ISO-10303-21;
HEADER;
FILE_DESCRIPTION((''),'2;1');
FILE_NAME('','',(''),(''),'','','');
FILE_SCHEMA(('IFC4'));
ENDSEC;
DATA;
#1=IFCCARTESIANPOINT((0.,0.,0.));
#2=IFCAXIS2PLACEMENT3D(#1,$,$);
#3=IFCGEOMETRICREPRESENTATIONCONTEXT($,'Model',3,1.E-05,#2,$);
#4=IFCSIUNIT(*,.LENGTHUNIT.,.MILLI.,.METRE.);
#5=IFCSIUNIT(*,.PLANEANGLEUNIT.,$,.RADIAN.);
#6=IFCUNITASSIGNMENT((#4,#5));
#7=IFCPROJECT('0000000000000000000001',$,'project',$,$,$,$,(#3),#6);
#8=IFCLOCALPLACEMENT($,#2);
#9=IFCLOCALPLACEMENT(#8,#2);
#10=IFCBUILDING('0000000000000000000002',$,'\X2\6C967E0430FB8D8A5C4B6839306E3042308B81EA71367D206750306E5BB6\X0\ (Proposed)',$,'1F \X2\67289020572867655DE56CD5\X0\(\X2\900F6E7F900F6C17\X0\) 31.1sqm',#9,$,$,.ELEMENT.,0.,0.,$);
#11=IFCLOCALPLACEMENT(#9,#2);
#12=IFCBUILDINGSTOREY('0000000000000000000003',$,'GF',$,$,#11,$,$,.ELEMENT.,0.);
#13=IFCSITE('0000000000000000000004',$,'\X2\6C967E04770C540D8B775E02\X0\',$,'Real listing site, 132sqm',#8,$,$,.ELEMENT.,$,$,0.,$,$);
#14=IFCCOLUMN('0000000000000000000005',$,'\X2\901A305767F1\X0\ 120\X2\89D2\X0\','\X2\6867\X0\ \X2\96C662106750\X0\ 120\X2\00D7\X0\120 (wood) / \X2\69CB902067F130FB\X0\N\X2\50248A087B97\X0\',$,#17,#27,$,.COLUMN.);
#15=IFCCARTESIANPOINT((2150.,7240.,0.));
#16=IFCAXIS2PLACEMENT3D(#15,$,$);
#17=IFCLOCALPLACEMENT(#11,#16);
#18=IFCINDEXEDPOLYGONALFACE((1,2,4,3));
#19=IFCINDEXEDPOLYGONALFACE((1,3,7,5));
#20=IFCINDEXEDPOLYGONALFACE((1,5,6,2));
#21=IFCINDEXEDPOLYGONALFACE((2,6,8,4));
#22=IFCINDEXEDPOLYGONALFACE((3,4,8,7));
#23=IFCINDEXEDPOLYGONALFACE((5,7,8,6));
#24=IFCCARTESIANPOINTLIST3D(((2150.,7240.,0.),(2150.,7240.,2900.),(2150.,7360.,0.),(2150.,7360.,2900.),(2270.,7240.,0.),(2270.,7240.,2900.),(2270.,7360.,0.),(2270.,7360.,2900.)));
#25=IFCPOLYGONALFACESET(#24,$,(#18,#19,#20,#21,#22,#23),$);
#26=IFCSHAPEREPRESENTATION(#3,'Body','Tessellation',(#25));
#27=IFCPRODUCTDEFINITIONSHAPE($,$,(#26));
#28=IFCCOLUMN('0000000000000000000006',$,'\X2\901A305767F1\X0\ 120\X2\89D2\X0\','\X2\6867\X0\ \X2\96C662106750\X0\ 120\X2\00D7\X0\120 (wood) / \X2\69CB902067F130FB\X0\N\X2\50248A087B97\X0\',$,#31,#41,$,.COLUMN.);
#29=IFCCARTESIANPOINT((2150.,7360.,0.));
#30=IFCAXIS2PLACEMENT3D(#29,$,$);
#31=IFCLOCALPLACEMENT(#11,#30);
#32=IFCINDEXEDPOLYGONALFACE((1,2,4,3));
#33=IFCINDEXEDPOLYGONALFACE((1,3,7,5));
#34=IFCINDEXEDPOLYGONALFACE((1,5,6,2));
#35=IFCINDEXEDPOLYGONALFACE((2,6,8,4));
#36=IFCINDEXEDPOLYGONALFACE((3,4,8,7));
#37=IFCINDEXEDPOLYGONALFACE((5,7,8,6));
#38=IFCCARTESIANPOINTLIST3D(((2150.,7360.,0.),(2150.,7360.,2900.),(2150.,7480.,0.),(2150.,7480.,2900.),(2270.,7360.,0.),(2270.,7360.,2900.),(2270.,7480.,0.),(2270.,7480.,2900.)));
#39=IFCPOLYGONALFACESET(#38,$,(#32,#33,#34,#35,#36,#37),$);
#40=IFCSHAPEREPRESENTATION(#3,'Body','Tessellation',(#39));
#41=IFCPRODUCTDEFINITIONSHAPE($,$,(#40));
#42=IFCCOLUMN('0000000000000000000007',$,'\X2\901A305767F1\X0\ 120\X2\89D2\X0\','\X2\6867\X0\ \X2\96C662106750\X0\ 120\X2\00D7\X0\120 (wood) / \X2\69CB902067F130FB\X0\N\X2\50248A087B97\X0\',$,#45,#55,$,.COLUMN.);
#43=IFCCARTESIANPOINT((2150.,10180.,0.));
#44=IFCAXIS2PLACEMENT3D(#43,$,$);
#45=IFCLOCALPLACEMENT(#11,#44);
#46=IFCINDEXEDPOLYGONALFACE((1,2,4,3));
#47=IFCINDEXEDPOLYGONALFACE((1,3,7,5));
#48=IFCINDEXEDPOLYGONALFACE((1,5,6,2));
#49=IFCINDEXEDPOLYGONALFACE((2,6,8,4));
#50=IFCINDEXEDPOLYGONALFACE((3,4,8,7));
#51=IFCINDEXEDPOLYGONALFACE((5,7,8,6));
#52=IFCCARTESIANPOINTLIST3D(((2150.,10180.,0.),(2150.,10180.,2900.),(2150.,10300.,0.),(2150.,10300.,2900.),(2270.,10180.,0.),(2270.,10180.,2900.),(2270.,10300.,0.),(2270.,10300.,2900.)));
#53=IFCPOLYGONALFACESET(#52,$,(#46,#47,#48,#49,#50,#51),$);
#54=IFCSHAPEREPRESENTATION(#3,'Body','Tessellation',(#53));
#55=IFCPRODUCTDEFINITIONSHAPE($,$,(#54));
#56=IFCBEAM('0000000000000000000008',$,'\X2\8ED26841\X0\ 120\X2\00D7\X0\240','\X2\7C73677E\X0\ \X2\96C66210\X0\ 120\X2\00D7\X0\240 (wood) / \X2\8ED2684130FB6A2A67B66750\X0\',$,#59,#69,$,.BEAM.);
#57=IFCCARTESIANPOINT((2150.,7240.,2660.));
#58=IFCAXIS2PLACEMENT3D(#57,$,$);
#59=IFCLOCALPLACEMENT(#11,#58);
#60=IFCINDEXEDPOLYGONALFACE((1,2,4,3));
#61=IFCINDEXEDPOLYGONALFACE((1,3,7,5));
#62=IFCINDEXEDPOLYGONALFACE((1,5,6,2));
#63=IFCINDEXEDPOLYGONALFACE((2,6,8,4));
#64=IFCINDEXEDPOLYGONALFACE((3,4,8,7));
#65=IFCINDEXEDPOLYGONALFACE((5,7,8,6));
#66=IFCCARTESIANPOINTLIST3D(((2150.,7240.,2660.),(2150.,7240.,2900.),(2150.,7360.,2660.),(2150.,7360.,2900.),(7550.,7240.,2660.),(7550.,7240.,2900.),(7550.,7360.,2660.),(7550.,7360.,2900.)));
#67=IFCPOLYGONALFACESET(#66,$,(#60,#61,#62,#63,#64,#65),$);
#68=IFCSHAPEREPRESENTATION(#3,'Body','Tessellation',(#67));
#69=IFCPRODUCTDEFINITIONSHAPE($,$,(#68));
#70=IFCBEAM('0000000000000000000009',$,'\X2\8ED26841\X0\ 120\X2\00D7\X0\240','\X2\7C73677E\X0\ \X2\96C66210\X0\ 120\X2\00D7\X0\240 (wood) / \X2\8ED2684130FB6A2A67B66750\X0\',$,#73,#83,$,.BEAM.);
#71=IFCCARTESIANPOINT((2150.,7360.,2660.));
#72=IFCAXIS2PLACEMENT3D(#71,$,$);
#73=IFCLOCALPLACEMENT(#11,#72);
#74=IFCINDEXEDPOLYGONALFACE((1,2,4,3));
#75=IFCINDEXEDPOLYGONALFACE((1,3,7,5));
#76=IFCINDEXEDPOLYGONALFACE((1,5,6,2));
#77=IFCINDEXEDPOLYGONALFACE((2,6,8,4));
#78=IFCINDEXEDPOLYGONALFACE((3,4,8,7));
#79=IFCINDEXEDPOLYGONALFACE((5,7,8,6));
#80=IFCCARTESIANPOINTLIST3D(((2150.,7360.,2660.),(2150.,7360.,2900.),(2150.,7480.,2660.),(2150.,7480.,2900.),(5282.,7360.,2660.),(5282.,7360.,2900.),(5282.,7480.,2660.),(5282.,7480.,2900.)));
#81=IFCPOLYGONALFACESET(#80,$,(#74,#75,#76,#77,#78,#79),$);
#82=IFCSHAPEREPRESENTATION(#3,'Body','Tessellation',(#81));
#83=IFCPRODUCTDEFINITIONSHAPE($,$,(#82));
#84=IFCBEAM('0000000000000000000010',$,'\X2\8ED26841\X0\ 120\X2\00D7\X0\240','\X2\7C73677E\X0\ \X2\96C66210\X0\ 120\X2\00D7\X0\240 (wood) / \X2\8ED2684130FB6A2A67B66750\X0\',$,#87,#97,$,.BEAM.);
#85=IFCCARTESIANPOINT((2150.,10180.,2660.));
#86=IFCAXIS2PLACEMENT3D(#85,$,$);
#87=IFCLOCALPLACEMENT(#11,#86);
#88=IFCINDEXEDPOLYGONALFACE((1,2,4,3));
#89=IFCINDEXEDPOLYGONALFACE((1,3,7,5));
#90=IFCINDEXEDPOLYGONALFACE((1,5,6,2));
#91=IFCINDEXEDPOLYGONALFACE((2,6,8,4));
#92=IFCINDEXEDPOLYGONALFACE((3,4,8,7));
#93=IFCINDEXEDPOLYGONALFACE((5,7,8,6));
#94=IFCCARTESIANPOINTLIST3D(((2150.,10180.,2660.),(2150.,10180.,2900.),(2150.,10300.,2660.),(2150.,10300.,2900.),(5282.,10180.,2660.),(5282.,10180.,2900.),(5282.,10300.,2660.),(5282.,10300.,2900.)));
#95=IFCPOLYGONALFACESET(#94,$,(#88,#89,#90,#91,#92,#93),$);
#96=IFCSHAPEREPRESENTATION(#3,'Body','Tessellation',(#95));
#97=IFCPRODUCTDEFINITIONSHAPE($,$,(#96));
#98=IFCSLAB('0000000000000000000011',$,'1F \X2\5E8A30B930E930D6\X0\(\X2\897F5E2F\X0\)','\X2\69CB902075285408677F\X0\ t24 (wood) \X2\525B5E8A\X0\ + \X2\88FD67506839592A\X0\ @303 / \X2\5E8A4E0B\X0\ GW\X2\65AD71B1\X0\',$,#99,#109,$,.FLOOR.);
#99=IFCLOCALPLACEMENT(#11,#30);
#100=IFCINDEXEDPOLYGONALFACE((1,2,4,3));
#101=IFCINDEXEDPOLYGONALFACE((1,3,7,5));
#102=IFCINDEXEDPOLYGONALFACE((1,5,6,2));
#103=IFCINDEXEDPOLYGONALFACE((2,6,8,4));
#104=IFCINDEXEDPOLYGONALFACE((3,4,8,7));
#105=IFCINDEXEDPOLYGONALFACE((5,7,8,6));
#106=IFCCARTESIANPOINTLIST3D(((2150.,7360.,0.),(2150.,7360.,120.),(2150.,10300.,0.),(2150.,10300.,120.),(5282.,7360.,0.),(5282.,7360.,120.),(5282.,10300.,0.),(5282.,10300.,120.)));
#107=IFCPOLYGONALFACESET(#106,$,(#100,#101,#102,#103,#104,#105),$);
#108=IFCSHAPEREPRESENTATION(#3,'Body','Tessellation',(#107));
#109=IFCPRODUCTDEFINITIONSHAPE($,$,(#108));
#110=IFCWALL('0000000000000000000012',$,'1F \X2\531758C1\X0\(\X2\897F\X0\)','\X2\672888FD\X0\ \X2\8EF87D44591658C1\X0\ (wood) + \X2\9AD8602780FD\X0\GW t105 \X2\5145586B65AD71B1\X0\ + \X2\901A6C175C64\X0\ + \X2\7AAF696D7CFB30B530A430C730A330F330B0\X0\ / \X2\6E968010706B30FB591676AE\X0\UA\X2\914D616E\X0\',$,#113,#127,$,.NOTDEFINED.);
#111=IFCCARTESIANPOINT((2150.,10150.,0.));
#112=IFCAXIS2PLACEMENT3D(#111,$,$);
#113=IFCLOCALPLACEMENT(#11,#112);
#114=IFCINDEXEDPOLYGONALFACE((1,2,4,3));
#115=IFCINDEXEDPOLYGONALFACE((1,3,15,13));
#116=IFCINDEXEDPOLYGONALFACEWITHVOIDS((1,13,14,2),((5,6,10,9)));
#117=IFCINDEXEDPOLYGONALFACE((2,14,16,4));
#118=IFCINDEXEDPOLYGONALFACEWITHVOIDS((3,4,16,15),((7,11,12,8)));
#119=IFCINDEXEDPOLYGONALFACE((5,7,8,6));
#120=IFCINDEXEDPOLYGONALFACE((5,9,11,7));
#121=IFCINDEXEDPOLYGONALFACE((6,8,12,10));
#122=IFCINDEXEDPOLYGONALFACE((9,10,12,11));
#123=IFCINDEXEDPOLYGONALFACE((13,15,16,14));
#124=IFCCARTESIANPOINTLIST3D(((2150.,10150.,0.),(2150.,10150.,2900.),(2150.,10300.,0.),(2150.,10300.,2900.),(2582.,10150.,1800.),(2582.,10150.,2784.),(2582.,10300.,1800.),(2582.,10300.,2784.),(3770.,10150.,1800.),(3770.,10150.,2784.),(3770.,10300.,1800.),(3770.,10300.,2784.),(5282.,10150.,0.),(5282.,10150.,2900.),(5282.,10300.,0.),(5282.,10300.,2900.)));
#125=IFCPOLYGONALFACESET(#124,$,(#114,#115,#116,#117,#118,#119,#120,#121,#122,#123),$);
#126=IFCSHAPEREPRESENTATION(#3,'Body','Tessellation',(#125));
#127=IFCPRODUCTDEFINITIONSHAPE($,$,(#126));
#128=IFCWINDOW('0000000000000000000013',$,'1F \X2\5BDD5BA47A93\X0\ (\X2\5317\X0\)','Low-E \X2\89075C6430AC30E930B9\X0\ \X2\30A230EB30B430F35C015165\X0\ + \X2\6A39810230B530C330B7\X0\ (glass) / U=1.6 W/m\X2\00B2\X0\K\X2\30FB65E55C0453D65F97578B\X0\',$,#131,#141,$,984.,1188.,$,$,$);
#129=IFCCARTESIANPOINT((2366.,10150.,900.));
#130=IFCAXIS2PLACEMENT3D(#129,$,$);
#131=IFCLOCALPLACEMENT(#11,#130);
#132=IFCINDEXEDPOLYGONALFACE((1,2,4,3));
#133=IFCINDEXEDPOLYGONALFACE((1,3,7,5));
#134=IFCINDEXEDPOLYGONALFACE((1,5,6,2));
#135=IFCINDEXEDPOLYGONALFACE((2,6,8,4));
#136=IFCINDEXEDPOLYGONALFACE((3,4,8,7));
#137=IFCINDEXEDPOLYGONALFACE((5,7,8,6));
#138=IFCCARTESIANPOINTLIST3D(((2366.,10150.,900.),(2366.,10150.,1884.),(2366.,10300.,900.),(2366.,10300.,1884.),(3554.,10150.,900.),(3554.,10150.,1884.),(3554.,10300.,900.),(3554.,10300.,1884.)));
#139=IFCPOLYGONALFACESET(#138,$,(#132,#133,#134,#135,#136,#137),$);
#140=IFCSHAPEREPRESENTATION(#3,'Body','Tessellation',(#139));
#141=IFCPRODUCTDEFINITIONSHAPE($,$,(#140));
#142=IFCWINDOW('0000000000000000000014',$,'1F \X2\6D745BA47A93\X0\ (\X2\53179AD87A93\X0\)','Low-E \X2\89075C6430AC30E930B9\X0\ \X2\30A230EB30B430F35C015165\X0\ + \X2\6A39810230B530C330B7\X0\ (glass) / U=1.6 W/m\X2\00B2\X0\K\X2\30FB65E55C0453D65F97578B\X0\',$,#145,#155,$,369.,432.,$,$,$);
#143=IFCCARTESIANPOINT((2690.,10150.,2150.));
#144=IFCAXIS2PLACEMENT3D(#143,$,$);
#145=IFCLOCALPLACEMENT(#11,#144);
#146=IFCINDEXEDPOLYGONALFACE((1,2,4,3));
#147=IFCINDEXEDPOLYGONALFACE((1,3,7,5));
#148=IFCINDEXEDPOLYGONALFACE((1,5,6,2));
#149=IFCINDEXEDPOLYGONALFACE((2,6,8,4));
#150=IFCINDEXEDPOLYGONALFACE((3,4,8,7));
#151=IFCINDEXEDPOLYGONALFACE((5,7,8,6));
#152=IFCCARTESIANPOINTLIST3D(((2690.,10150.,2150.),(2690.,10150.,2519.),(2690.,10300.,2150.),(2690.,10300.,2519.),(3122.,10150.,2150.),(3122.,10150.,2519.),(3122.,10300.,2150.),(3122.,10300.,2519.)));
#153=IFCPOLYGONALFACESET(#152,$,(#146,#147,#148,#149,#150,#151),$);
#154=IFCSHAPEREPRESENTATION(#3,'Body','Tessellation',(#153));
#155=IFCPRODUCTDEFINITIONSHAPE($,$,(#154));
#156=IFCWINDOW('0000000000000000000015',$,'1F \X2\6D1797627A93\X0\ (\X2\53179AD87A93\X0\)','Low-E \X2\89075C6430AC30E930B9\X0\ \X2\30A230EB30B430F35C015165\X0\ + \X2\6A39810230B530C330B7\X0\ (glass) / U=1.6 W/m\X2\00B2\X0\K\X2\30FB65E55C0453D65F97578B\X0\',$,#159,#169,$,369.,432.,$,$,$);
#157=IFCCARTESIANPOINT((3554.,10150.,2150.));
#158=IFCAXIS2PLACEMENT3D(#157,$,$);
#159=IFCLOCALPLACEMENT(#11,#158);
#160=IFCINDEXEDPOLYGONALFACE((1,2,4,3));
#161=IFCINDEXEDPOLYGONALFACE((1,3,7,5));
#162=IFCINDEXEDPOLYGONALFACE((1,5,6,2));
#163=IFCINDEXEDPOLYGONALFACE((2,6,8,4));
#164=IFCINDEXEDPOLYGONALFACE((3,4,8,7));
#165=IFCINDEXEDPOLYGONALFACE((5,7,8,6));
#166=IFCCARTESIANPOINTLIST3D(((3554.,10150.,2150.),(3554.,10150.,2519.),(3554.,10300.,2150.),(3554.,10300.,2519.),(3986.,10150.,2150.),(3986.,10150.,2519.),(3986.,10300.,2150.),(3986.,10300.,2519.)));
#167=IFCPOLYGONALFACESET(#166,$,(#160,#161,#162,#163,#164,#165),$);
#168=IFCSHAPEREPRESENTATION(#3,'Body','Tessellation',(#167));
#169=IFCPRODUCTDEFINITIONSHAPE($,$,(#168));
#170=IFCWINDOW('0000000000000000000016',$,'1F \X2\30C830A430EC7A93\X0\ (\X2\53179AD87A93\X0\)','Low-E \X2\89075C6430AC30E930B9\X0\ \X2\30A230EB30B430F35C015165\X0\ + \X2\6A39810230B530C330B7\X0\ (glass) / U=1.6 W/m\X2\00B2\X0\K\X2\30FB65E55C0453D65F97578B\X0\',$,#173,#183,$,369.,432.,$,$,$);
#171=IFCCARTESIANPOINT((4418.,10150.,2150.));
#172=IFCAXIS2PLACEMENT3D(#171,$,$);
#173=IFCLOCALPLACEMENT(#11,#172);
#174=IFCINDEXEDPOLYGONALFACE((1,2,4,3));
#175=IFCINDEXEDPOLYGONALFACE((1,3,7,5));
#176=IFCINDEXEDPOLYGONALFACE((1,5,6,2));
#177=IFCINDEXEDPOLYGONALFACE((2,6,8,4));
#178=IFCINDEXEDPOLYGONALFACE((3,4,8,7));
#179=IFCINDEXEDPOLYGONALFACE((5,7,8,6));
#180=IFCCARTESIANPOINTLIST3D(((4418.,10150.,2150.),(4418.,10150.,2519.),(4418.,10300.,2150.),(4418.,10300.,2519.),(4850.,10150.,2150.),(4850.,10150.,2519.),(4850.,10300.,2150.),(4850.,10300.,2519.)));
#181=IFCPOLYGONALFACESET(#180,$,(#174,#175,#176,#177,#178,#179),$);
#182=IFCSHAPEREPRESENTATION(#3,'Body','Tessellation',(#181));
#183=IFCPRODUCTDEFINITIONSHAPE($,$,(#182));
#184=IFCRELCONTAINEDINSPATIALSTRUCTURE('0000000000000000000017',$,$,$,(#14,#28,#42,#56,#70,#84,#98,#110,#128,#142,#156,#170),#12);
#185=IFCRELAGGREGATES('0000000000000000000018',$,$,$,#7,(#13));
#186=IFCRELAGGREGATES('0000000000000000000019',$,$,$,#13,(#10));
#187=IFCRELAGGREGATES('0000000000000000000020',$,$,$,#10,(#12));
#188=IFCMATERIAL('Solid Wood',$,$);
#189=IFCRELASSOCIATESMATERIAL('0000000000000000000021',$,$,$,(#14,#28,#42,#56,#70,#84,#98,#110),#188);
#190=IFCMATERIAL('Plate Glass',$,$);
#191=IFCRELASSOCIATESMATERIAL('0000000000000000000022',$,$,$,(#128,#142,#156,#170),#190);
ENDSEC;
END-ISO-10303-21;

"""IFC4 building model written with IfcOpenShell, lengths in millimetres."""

from ifc_helpers import new_model, si_unit, frame, frame_2d, origin, place, context, project, spatial, rectangle, extrude, material, element, fill, save


model = new_model("IFC4")

# Units and contexts
model_context = context("Model", 3, precision=1e-05, world=origin())
ifc_project = project(units=[si_unit("LENGTHUNIT", "METRE", prefix="MILLI"), si_unit("PLANEANGLEUNIT", "RADIAN")], contexts=[model_context])

# Site, building, storey
site_placement = place(None, origin())
site = spatial("IfcSite", under=ifc_project, at=site_placement, Name="沖縄県名護市", ObjectType="Real listing site, 132sqm", CompositionType="ELEMENT", RefElevation=0.0)
building_placement = place(site_placement, origin())
building = spatial("IfcBuilding", under=site, at=building_placement, Name="沖縄・越屋根のある自然素材の家 (Proposed)", ObjectType="1F 木造在来工法(透湿透気) 31.1sqm", CompositionType="ELEMENT", ElevationOfRefHeight=0.0, ElevationOfTerrain=0.0)
storey_placement = place(building_placement, origin())
storey = spatial("IfcBuildingStorey", under=building, at=storey_placement, Name="GF", CompositionType="ELEMENT", Elevation=0.0)

# Columns
ifc_material_1 = material(Name="Solid Wood")
column_1_placement = place(storey_placement, frame((2150.0, 7240.0, 0.0)))
element("IfcColumn", 1, at=column_1_placement, inside=storey, material=ifc_material_1, Name="通し柱 120角", Description="桧 集成材 120×120 (wood) / 構造柱・N値計算", PredefinedType="COLUMN", context=model_context, shape_type="SweptSolid", body=[
    extrude(rectangle(XDim=120.0, YDim=120.0, at=frame_2d((60.0, 60.0))), frame((2150.0, 7240.0, 0.0)), (0.0, 0.0, 1.0), 2900.0),
])
column_2_placement = place(storey_placement, frame((2150.0, 7360.0, 0.0)))
element("IfcColumn", 2, at=column_2_placement, inside=storey, material=ifc_material_1, Name="通し柱 120角", Description="桧 集成材 120×120 (wood) / 構造柱・N値計算", PredefinedType="COLUMN", context=model_context, shape_type="SweptSolid", body=[
    extrude(rectangle(XDim=120.0, YDim=120.0, at=frame_2d((60.0, 60.0))), frame((2150.0, 7360.0, 0.0)), (0.0, 0.0, 1.0), 2900.0),
])
column_3_placement = place(storey_placement, frame((2150.0, 10180.0, 0.0)))
element("IfcColumn", 3, at=column_3_placement, inside=storey, material=ifc_material_1, Name="通し柱 120角", Description="桧 集成材 120×120 (wood) / 構造柱・N値計算", PredefinedType="COLUMN", context=model_context, shape_type="SweptSolid", body=[
    extrude(rectangle(XDim=120.0, YDim=120.0, at=frame_2d((60.0, 60.0))), frame((2150.0, 10180.0, 0.0)), (0.0, 0.0, 1.0), 2900.0),
])

# Beams
beam_1_placement = place(storey_placement, frame((2150.0, 7240.0, 2660.0)))
element("IfcBeam", 4, at=beam_1_placement, inside=storey, material=ifc_material_1, Name="軒桁 120×240", Description="米松 集成 120×240 (wood) / 軒桁・横架材", PredefinedType="BEAM", context=model_context, shape_type="SweptSolid", body=[
    extrude(rectangle(XDim=5400.0, YDim=120.0, at=frame_2d((2700.0, 60.0))), frame((2150.0, 7240.0, 2660.0)), (0.0, 0.0, 1.0), 240.0),
])
beam_2_placement = place(storey_placement, frame((2150.0, 7360.0, 2660.0)))
element("IfcBeam", 5, at=beam_2_placement, inside=storey, material=ifc_material_1, Name="軒桁 120×240", Description="米松 集成 120×240 (wood) / 軒桁・横架材", PredefinedType="BEAM", context=model_context, shape_type="SweptSolid", body=[
    extrude(rectangle(XDim=3132.0, YDim=120.0, at=frame_2d((1566.0, 60.0))), frame((2150.0, 7360.0, 2660.0)), (0.0, 0.0, 1.0), 240.0),
])
beam_3_placement = place(storey_placement, frame((2150.0, 10180.0, 2660.0)))
element("IfcBeam", 6, at=beam_3_placement, inside=storey, material=ifc_material_1, Name="軒桁 120×240", Description="米松 集成 120×240 (wood) / 軒桁・横架材", PredefinedType="BEAM", context=model_context, shape_type="SweptSolid", body=[
    extrude(rectangle(XDim=3132.0, YDim=120.0, at=frame_2d((1566.0, 60.0))), frame((2150.0, 10180.0, 2660.0)), (0.0, 0.0, 1.0), 240.0),
])

# Slab
slab_placement = place(storey_placement, frame((2150.0, 7360.0, 0.0)))
element("IfcSlab", 7, at=slab_placement, inside=storey, material=ifc_material_1, Name="1F 床スラブ(西帯)", Description="構造用合板 t24 (wood) 剛床 + 製材根太 @303 / 床下 GW断熱", PredefinedType="FLOOR", context=model_context, shape_type="SweptSolid", body=[
    extrude(rectangle(XDim=3132.0, YDim=2940.0, at=frame_2d((1566.0, 1470.0))), frame((2150.0, 7360.0, 0.0)), (0.0, 0.0, 1.0), 120.0),
])

# Wall, openings, windows
wall_1_placement = place(storey_placement, frame((2150.0, 10150.0, 0.0)))
wall_1 = element("IfcWall", 8, at=wall_1_placement, inside=storey, material=ifc_material_1, Name="1F 北壁(西)", Description="木製 軸組外壁 (wood) + 高性能GW t105 充填断熱 + 通気層 + 窯業系サイディング / 準耐火・外皮UA配慮", PredefinedType="NOTDEFINED", context=model_context, shape_type="SweptSolid", body=[
    extrude(rectangle(XDim=3132.0, YDim=150.0, at=frame_2d((1566.0, 75.0))), frame((2150.0, 10150.0, 0.0)), (0.0, 0.0, 1.0), 2900.0),
])
opening_1_placement = place(storey_placement, frame((2366.0, 10150.0, 900.0)))
opening_1 = element("IfcOpeningElement", 9, at=opening_1_placement, cuts=wall_1, PredefinedType="NOTDEFINED", context=model_context, shape_type="SweptSolid", body=[
    extrude(rectangle(XDim=1188.0, YDim=150.0, at=frame_2d((594.0, 75.0))), frame((2366.0, 10150.0, 900.0)), (0.0, 0.0, 1.0), 984.0),
])
opening_2_placement = place(storey_placement, frame((2690.0, 10150.0, 2150.0)))
opening_2 = element("IfcOpeningElement", 10, at=opening_2_placement, cuts=wall_1, PredefinedType="NOTDEFINED", context=model_context, shape_type="SweptSolid", body=[
    extrude(rectangle(XDim=432.0, YDim=150.0, at=frame_2d((216.0, 75.0))), frame((2690.0, 10150.0, 2150.0)), (0.0, 0.0, 1.0), 369.0),
])
opening_3_placement = place(storey_placement, frame((3554.0, 10150.0, 2150.0)))
opening_3 = element("IfcOpeningElement", 11, at=opening_3_placement, cuts=wall_1, PredefinedType="NOTDEFINED", context=model_context, shape_type="SweptSolid", body=[
    extrude(rectangle(XDim=432.0, YDim=150.0, at=frame_2d((216.0, 75.0))), frame((3554.0, 10150.0, 2150.0)), (0.0, 0.0, 1.0), 369.0),
])
opening_4_placement = place(storey_placement, frame((4418.0, 10150.0, 2150.0)))
opening_4 = element("IfcOpeningElement", 12, at=opening_4_placement, cuts=wall_1, PredefinedType="NOTDEFINED", context=model_context, shape_type="SweptSolid", body=[
    extrude(rectangle(XDim=432.0, YDim=150.0, at=frame_2d((216.0, 75.0))), frame((4418.0, 10150.0, 2150.0)), (0.0, 0.0, 1.0), 369.0),
])
ifc_material_2 = material(Name="Plate Glass")
window_1_placement = place(storey_placement, frame((2366.0, 10150.0, 900.0)))
window_1 = element("IfcWindow", 13, at=window_1_placement, inside=storey, material=ifc_material_2, Name="1F 寝室窓 (北)", Description="Low-E 複層ガラス アルゴン封入 + 樹脂サッシ (glass) / U=1.6 W/m²K・日射取得型", OverallHeight=984.0, OverallWidth=1188.0, context=model_context, shape_type="SweptSolid", body=[
    extrude(rectangle(XDim=1188.0, YDim=150.0, at=frame_2d((594.0, 75.0))), frame((2366.0, 10150.0, 900.0)), (0.0, 0.0, 1.0), 984.0),
])
fill(opening_1, window_1)
window_2_placement = place(storey_placement, frame((2690.0, 10150.0, 2150.0)))
window_2 = element("IfcWindow", 14, at=window_2_placement, inside=storey, material=ifc_material_2, Name="1F 浴室窓 (北高窓)", Description="Low-E 複層ガラス アルゴン封入 + 樹脂サッシ (glass) / U=1.6 W/m²K・日射取得型", OverallHeight=369.0, OverallWidth=432.0, context=model_context, shape_type="SweptSolid", body=[
    extrude(rectangle(XDim=432.0, YDim=150.0, at=frame_2d((216.0, 75.0))), frame((2690.0, 10150.0, 2150.0)), (0.0, 0.0, 1.0), 369.0),
])
fill(opening_2, window_2)
window_3_placement = place(storey_placement, frame((3554.0, 10150.0, 2150.0)))
window_3 = element("IfcWindow", 15, at=window_3_placement, inside=storey, material=ifc_material_2, Name="1F 洗面窓 (北高窓)", Description="Low-E 複層ガラス アルゴン封入 + 樹脂サッシ (glass) / U=1.6 W/m²K・日射取得型", OverallHeight=369.0, OverallWidth=432.0, context=model_context, shape_type="SweptSolid", body=[
    extrude(rectangle(XDim=432.0, YDim=150.0, at=frame_2d((216.0, 75.0))), frame((3554.0, 10150.0, 2150.0)), (0.0, 0.0, 1.0), 369.0),
])
fill(opening_3, window_3)
window_4_placement = place(storey_placement, frame((4418.0, 10150.0, 2150.0)))
window_4 = element("IfcWindow", 16, at=window_4_placement, inside=storey, material=ifc_material_2, Name="1F トイレ窓 (北高窓)", Description="Low-E 複層ガラス アルゴン封入 + 樹脂サッシ (glass) / U=1.6 W/m²K・日射取得型", OverallHeight=369.0, OverallWidth=432.0, context=model_context, shape_type="SweptSolid", body=[
    extrude(rectangle(XDim=432.0, YDim=150.0, at=frame_2d((216.0, 75.0))), frame((4418.0, 10150.0, 2150.0)), (0.0, 0.0, 1.0), 369.0),
])
fill(opening_4, window_4)

save(model, "model.ifc")
